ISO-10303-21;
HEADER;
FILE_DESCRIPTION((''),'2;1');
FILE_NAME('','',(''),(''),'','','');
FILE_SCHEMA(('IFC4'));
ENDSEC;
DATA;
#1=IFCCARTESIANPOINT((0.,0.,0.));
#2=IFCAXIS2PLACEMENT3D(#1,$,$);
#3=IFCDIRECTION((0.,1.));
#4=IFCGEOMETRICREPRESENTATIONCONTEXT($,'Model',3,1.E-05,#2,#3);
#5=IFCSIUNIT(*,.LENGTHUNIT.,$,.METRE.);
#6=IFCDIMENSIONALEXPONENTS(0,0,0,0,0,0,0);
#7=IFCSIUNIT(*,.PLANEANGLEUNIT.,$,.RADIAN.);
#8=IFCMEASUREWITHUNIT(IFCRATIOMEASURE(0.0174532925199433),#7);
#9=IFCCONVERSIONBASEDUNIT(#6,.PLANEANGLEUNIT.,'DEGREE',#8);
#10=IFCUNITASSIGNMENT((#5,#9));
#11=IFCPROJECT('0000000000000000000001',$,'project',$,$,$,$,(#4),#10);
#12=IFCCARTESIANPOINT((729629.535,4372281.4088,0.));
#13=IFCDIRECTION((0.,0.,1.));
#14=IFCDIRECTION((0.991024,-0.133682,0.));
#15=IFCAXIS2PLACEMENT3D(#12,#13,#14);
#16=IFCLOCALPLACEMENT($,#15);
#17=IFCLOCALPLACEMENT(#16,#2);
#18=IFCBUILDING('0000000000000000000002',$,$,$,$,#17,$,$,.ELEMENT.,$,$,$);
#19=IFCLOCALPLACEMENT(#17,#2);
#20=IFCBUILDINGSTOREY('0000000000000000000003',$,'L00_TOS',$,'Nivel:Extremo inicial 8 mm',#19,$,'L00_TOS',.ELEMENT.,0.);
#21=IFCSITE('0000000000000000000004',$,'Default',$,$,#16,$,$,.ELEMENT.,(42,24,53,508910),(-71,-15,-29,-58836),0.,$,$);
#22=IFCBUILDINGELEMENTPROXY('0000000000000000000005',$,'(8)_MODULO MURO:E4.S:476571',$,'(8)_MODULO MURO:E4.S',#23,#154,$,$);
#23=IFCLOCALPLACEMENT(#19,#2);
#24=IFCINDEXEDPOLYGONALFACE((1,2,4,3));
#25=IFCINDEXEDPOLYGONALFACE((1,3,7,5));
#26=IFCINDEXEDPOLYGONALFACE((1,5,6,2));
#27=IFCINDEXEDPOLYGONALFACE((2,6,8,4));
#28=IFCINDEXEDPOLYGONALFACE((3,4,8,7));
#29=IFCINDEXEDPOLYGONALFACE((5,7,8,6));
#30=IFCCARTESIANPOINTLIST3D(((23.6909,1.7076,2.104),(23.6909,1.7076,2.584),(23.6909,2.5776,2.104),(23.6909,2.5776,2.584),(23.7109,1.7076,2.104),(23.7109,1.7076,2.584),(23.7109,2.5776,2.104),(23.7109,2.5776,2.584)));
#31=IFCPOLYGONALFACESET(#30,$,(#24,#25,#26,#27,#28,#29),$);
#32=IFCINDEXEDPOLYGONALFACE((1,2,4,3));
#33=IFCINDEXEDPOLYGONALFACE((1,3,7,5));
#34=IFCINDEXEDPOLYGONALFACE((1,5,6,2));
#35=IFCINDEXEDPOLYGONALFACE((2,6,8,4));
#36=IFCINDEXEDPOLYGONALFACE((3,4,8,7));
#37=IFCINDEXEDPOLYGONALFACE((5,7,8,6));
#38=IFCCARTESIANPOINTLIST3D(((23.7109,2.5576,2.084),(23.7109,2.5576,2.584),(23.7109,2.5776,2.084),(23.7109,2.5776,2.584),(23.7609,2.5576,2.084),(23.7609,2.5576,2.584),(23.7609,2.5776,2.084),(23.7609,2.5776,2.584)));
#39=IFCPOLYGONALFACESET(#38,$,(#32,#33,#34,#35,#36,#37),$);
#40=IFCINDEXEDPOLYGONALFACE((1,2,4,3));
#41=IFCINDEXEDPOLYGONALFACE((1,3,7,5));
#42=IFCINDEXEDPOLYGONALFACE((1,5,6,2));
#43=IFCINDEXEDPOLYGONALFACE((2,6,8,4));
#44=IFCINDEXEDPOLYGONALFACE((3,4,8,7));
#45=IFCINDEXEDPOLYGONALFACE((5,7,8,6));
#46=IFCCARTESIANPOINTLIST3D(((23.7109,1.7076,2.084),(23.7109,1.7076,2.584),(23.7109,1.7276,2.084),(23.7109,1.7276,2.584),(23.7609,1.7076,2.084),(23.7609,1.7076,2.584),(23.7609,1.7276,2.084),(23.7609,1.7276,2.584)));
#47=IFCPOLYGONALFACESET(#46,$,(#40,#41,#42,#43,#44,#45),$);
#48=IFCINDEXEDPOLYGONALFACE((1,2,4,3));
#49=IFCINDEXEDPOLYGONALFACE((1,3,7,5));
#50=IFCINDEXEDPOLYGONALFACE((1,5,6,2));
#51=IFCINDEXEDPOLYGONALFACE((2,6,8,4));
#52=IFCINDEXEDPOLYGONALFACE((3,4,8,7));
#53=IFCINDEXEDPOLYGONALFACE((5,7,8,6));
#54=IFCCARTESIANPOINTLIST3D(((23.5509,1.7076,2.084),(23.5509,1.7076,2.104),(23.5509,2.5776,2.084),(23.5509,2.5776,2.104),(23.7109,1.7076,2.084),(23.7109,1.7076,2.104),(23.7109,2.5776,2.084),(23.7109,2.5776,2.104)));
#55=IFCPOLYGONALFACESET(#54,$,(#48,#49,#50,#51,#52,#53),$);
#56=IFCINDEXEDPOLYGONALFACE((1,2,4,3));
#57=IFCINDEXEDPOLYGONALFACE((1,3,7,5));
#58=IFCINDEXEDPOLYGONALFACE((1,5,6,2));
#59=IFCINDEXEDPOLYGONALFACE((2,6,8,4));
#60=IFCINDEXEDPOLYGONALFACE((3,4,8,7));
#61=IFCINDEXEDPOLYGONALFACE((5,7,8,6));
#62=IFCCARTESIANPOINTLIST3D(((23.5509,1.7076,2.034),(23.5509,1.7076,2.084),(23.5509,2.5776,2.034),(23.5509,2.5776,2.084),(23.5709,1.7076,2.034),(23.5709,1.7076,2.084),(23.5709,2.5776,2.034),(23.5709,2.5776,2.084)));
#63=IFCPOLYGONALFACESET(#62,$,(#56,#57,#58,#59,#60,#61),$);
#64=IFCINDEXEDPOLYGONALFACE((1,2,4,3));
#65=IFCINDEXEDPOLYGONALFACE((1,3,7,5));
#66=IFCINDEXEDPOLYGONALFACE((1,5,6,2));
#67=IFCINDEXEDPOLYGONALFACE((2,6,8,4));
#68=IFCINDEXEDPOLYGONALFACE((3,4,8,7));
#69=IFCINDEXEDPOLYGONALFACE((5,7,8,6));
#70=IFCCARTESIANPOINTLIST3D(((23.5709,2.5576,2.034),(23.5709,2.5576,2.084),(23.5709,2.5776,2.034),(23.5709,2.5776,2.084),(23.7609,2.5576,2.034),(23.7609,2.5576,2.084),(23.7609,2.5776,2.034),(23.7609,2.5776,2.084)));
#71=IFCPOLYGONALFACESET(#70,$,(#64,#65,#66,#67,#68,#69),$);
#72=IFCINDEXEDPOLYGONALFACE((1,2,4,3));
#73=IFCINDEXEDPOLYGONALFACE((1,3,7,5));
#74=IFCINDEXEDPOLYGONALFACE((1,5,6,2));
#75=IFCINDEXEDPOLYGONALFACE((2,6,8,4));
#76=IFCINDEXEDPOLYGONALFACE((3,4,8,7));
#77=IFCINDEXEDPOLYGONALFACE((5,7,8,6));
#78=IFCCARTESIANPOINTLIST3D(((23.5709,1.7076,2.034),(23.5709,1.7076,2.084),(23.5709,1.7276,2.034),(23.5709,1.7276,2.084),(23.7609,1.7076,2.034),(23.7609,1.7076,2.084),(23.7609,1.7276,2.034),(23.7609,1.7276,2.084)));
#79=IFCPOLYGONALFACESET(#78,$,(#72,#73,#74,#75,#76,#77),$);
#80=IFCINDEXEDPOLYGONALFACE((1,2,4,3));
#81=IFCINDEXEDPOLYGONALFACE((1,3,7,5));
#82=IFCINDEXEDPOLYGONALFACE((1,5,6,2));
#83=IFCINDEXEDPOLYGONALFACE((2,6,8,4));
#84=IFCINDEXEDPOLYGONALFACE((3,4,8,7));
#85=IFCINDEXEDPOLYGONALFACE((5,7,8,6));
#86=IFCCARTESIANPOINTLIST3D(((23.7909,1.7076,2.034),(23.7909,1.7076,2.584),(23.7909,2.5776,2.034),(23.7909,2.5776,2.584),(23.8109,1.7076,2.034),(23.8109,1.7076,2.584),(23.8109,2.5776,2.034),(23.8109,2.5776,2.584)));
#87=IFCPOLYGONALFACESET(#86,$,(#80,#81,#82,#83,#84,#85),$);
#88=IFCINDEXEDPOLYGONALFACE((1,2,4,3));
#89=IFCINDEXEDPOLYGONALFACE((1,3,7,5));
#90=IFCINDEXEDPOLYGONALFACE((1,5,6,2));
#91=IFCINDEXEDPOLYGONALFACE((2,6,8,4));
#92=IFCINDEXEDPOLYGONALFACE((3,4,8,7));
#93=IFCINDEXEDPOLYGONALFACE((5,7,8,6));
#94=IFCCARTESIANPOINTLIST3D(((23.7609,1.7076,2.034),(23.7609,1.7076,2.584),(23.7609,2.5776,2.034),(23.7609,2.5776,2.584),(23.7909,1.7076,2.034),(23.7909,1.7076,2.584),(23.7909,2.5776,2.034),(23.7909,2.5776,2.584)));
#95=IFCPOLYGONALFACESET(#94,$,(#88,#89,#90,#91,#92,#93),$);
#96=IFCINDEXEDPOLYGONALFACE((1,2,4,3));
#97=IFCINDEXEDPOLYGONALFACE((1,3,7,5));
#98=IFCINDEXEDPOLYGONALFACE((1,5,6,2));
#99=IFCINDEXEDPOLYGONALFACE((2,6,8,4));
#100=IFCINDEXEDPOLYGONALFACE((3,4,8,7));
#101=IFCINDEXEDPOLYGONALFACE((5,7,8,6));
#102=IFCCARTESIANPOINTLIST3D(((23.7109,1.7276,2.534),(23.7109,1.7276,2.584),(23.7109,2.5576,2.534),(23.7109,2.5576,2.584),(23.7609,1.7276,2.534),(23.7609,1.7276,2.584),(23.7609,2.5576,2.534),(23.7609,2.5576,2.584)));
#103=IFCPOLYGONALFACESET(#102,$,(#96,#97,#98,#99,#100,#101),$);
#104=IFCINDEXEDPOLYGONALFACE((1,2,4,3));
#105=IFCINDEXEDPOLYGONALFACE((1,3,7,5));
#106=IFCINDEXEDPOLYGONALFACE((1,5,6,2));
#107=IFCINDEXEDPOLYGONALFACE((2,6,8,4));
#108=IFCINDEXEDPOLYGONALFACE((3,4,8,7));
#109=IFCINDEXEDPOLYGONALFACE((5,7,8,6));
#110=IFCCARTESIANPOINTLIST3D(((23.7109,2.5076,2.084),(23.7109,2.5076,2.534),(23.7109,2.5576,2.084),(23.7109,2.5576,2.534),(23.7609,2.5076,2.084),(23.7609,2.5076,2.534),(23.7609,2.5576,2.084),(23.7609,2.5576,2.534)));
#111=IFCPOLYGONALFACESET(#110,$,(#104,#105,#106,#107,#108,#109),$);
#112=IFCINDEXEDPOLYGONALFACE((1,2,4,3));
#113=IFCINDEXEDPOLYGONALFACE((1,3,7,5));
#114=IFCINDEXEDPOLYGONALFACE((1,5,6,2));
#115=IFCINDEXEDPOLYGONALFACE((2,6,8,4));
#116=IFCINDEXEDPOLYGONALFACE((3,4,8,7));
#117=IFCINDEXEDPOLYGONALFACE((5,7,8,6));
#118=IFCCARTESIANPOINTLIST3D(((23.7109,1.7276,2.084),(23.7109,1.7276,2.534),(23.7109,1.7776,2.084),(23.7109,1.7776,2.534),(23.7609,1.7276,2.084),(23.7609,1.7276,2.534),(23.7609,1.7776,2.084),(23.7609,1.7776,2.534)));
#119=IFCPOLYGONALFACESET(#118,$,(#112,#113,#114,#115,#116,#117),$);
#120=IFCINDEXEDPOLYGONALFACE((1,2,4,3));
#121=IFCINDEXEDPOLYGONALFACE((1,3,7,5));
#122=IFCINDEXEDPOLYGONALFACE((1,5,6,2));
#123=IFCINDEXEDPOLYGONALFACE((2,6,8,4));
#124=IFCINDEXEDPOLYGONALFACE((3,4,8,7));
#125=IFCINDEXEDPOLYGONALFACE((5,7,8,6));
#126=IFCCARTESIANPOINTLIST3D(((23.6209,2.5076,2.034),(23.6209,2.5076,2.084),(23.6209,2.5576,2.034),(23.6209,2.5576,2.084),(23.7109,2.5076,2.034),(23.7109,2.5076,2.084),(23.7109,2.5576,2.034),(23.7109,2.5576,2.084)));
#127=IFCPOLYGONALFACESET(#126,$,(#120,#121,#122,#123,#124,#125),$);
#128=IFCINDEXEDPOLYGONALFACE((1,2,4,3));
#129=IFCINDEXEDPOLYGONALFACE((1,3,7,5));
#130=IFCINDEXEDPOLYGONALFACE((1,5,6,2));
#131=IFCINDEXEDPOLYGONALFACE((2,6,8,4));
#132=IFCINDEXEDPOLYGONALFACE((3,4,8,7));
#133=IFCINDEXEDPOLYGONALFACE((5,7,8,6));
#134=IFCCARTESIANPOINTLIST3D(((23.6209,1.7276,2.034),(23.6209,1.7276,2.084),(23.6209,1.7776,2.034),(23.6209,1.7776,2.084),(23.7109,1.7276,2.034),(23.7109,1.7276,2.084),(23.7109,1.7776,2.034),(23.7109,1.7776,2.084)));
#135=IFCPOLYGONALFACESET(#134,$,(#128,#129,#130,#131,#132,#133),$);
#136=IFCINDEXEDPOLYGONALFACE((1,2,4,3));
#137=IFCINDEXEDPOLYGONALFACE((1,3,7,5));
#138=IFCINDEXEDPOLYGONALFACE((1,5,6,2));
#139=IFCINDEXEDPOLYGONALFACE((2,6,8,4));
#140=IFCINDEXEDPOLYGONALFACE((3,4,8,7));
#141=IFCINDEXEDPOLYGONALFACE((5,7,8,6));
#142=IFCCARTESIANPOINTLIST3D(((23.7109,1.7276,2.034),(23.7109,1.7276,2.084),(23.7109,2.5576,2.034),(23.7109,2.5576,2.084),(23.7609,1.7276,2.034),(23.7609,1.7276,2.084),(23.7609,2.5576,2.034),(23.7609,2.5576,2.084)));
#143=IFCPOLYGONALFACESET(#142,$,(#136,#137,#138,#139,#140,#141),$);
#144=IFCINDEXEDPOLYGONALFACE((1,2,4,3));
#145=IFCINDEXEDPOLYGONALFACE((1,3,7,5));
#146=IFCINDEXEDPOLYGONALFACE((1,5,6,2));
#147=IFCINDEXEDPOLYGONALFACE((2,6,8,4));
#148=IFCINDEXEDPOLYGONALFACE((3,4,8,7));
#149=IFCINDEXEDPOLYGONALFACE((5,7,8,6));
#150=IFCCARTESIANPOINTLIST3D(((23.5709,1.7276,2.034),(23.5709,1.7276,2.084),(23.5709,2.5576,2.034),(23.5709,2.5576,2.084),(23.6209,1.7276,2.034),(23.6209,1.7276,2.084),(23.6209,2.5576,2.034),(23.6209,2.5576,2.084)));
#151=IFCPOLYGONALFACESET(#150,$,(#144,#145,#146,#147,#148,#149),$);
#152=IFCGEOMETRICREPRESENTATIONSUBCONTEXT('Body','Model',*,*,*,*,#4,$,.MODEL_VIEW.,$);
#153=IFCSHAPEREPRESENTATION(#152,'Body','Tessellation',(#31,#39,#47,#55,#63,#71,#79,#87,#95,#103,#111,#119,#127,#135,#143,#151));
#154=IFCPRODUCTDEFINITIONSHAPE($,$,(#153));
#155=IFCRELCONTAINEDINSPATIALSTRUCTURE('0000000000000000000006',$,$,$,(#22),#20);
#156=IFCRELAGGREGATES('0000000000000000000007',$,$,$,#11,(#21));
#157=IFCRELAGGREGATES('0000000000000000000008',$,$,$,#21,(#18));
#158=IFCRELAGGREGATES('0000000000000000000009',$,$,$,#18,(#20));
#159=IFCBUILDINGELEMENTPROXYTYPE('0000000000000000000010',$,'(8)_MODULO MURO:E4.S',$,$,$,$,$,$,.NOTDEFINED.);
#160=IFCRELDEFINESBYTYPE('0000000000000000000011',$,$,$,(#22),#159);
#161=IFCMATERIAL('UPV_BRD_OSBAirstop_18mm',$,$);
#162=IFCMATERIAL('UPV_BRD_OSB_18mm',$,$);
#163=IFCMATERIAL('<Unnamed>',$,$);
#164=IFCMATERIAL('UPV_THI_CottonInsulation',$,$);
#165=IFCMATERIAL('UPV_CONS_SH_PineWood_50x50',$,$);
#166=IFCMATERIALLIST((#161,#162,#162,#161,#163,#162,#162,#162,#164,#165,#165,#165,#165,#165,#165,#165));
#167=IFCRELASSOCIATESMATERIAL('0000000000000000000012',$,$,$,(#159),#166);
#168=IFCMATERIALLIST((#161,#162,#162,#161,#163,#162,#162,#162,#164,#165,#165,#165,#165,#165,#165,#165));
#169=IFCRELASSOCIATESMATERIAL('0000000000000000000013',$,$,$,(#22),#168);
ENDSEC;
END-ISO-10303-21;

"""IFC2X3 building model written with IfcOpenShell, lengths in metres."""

from ifc_helpers import new_model, entity, si_unit, converted_unit, direction, frame, frame_2d, origin, origin_2d_with_axis, place, context, subcontext, project, spatial, rectangle, extrude, source, transform, mapped, material, material_list, type_object, type_shapes, element, save


model = new_model("IFC2X3")

# Units and contexts
model_context = context("Model", 3, precision=1e-05, world=origin(), true_north=direction((0.0, 1.0)))
body_context = subcontext(model_context, "Body", "Model", "MODEL_VIEW")
ifc_project = project(units=[si_unit("LENGTHUNIT", "METRE"), converted_unit("PLANEANGLEUNIT", "DEGREE", entity("IfcRatioMeasure", 0.0174532925199433), si_unit("PLANEANGLEUNIT", "RADIAN"), dimensions=[0, 0, 0, 0, 0, 0, 0])], contexts=[model_context])

# Site, building, storey
site_placement = place(None, frame((729629.535, 4372281.4088, 0.0), z_axis=(0.0, 0.0, 1.0), x_axis=(0.991024, -0.133682, 0.0)))
site = spatial("IfcSite", under=ifc_project, at=site_placement, Name="Default", CompositionType="ELEMENT", RefLatitude=(42, 24, 53, 508910), RefLongitude=(-71, -15, -29, -58836), RefElevation=0.0)
building_placement = place(site_placement, origin())
building = spatial("IfcBuilding", under=site, at=building_placement, CompositionType="ELEMENT")
storey_placement = place(building_placement, origin())
storey = spatial("IfcBuildingStorey", under=building, at=storey_placement, Name="L00_TOS", ObjectType="Nivel:Extremo inicial 8 mm", LongName="L00_TOS", CompositionType="ELEMENT", Elevation=0.0)

# Building element proxy
ifc_material_1 = material(Name="UPV_BRD_OSBAirstop_18mm")
ifc_material_2 = material(Name="UPV_BRD_OSB_18mm")
ifc_material_3 = material(Name="UPV_THI_CottonInsulation")
ifc_material_4 = material(Name="<Unnamed>")
ifc_material_5 = material(Name="UPV_CONS_SH_PineWood_50x50")
ifc_material_list_1 = material_list([ifc_material_1, ifc_material_2, ifc_material_2, ifc_material_1, ifc_material_4, ifc_material_2, ifc_material_2, ifc_material_2, ifc_material_3, ifc_material_5, ifc_material_5, ifc_material_5, ifc_material_5, ifc_material_5, ifc_material_5, ifc_material_5])
ifc_material_list_2 = material_list([ifc_material_1, ifc_material_2, ifc_material_2, ifc_material_1, ifc_material_4, ifc_material_2, ifc_material_2, ifc_material_2, ifc_material_3, ifc_material_5, ifc_material_5, ifc_material_5, ifc_material_5, ifc_material_5, ifc_material_5, ifc_material_5])
building_element_proxy_type_1 = type_object("IfcBuildingElementProxyType", Name="(8)_MODULO MURO:E4.S", PredefinedType="NOTDEFINED", material=ifc_material_list_2)
shared_shape_1 = source(origin(), body_context, "Body", "SweptSolid", [
    extrude(rectangle(XDim=0.87, YDim=0.02, at=frame_2d((0.0, 0.0), x_axis=(1.0, 0.0))), frame((0.0, 0.035, 0.07), z_axis=(0.0, 0.0, 1.0), x_axis=(-1.0, 0.0, 0.0)), (0.0, 0.0, 1.0), 0.48),
    extrude(rectangle(XDim=0.05, YDim=0.02, at=frame_2d((0.0, 0.0), x_axis=(1.0, 0.0))), frame((-0.425, 0.07, 0.05), z_axis=(0.0, 0.0, 1.0), x_axis=(0.0, -1.0, 0.0)), (0.0, 0.0, 1.0), 0.5),
    extrude(rectangle(XDim=0.05, YDim=0.02, at=origin_2d_with_axis()), frame((0.425, 0.07, 0.05), z_axis=(0.0, 0.0, 1.0), x_axis=(0.0, -1.0, 0.0)), (0.0, 0.0, 1.0), 0.5),
    extrude(rectangle(XDim=0.87, YDim=0.16, at=origin_2d_with_axis()), frame((0.0, -0.035, 0.05)), (0.0, 0.0, 1.0), 0.02),
    extrude(rectangle(XDim=0.87, YDim=0.02, at=origin_2d_with_axis()), frame((0.0, -0.105, 0.0), z_axis=(0.0, 0.0, 1.0), x_axis=(-1.0, 0.0, 0.0)), (0.0, 0.0, 1.0), 0.05),
    extrude(rectangle(XDim=0.19, YDim=0.02, at=frame_2d((0.0, 0.0), x_axis=(1.0, 0.0))), frame((-0.425, 0.0, 0.0), z_axis=(0.0, 0.0, 1.0), x_axis=(0.0, -1.0, 0.0)), (0.0, 0.0, 1.0), 0.05),
    extrude(rectangle(XDim=0.19, YDim=0.02, at=origin_2d_with_axis()), frame((0.425, 0.0, 0.0), z_axis=(0.0, 0.0, 1.0), x_axis=(0.0, -1.0, 0.0)), (0.0, 0.0, 1.0), 0.05),
    extrude(rectangle(XDim=0.87, YDim=0.02, at=frame_2d((0.0, 0.0), x_axis=(1.0, 0.0))), frame((0.0, 0.135, 0.0), z_axis=(0.0, 0.0, 1.0), x_axis=(-1.0, 0.0, 0.0)), (0.0, 0.0, 1.0), 0.55),
    extrude(rectangle(XDim=0.87, YDim=0.03, at=origin_2d_with_axis()), frame((0.0, 0.11, 0.0)), (0.0, 0.0, 1.0), 0.55),
    extrude(rectangle(XDim=0.05, YDim=0.83, at=origin_2d_with_axis()), frame((0.0, 0.07, 0.5), z_axis=(0.0, 0.0, 1.0), x_axis=(0.0, -1.0, 0.0)), (0.0, 0.0, 1.0), 0.05),
    extrude(rectangle(XDim=0.05, YDim=0.05, at=origin_2d_with_axis()), frame((-0.39, 0.07, 0.05)), (0.0, 0.0, 1.0), 0.45),
    extrude(rectangle(XDim=0.05, YDim=0.05, at=origin_2d_with_axis()), frame((0.39, 0.07, 0.05), z_axis=(0.0, 0.0, 1.0), x_axis=(0.0, -1.0, 0.0)), (0.0, 0.0, 1.0), 0.45),
    extrude(rectangle(XDim=0.09, YDim=0.05, at=origin_2d_with_axis()), frame((-0.39, 0.0, 0.0), z_axis=(0.0, 0.0, 1.0), x_axis=(0.0, -1.0, 0.0)), (0.0, 0.0, 1.0), 0.05),
    extrude(rectangle(XDim=0.09, YDim=0.05, at=origin_2d_with_axis()), frame((0.39, 0.0, 0.0), z_axis=(0.0, 0.0, 1.0), x_axis=(0.0, -1.0, 0.0)), (0.0, 0.0, 1.0), 0.05),
    extrude(rectangle(XDim=0.05, YDim=0.83, at=origin_2d_with_axis()), frame((0.0, 0.07, 0.0), z_axis=(0.0, 0.0, 1.0), x_axis=(0.0, -1.0, 0.0)), (0.0, 0.0, 1.0), 0.05),
    extrude(rectangle(XDim=0.05, YDim=0.83, at=origin_2d_with_axis()), frame((0.0, -0.07, 0.0), z_axis=(0.0, 0.0, 1.0), x_axis=(0.0, -1.0, 0.0)), (0.0, 0.0, 1.0), 0.05),
])
type_shapes(building_element_proxy_type_1, [shared_shape_1])
proxy_1_placement = place(storey_placement, frame((23.6659, 2.1426, 2.034), z_axis=(0.0, 0.0, 1.0), x_axis=(0.0, -1.0, 0.0)))
element("IfcBuildingElementProxy", 1, at=proxy_1_placement, inside=storey, type_object=building_element_proxy_type_1, material=ifc_material_list_1, Name="(8)_MODULO MURO:E4.S:476571", ObjectType="(8)_MODULO MURO:E4.S", context=body_context, shape_type="MappedRepresentation", body=[
    mapped(shared_shape_1, transform((0.0, 0.0, 0.0), scale=1.0)),
])

save(model, "model.ifc")
